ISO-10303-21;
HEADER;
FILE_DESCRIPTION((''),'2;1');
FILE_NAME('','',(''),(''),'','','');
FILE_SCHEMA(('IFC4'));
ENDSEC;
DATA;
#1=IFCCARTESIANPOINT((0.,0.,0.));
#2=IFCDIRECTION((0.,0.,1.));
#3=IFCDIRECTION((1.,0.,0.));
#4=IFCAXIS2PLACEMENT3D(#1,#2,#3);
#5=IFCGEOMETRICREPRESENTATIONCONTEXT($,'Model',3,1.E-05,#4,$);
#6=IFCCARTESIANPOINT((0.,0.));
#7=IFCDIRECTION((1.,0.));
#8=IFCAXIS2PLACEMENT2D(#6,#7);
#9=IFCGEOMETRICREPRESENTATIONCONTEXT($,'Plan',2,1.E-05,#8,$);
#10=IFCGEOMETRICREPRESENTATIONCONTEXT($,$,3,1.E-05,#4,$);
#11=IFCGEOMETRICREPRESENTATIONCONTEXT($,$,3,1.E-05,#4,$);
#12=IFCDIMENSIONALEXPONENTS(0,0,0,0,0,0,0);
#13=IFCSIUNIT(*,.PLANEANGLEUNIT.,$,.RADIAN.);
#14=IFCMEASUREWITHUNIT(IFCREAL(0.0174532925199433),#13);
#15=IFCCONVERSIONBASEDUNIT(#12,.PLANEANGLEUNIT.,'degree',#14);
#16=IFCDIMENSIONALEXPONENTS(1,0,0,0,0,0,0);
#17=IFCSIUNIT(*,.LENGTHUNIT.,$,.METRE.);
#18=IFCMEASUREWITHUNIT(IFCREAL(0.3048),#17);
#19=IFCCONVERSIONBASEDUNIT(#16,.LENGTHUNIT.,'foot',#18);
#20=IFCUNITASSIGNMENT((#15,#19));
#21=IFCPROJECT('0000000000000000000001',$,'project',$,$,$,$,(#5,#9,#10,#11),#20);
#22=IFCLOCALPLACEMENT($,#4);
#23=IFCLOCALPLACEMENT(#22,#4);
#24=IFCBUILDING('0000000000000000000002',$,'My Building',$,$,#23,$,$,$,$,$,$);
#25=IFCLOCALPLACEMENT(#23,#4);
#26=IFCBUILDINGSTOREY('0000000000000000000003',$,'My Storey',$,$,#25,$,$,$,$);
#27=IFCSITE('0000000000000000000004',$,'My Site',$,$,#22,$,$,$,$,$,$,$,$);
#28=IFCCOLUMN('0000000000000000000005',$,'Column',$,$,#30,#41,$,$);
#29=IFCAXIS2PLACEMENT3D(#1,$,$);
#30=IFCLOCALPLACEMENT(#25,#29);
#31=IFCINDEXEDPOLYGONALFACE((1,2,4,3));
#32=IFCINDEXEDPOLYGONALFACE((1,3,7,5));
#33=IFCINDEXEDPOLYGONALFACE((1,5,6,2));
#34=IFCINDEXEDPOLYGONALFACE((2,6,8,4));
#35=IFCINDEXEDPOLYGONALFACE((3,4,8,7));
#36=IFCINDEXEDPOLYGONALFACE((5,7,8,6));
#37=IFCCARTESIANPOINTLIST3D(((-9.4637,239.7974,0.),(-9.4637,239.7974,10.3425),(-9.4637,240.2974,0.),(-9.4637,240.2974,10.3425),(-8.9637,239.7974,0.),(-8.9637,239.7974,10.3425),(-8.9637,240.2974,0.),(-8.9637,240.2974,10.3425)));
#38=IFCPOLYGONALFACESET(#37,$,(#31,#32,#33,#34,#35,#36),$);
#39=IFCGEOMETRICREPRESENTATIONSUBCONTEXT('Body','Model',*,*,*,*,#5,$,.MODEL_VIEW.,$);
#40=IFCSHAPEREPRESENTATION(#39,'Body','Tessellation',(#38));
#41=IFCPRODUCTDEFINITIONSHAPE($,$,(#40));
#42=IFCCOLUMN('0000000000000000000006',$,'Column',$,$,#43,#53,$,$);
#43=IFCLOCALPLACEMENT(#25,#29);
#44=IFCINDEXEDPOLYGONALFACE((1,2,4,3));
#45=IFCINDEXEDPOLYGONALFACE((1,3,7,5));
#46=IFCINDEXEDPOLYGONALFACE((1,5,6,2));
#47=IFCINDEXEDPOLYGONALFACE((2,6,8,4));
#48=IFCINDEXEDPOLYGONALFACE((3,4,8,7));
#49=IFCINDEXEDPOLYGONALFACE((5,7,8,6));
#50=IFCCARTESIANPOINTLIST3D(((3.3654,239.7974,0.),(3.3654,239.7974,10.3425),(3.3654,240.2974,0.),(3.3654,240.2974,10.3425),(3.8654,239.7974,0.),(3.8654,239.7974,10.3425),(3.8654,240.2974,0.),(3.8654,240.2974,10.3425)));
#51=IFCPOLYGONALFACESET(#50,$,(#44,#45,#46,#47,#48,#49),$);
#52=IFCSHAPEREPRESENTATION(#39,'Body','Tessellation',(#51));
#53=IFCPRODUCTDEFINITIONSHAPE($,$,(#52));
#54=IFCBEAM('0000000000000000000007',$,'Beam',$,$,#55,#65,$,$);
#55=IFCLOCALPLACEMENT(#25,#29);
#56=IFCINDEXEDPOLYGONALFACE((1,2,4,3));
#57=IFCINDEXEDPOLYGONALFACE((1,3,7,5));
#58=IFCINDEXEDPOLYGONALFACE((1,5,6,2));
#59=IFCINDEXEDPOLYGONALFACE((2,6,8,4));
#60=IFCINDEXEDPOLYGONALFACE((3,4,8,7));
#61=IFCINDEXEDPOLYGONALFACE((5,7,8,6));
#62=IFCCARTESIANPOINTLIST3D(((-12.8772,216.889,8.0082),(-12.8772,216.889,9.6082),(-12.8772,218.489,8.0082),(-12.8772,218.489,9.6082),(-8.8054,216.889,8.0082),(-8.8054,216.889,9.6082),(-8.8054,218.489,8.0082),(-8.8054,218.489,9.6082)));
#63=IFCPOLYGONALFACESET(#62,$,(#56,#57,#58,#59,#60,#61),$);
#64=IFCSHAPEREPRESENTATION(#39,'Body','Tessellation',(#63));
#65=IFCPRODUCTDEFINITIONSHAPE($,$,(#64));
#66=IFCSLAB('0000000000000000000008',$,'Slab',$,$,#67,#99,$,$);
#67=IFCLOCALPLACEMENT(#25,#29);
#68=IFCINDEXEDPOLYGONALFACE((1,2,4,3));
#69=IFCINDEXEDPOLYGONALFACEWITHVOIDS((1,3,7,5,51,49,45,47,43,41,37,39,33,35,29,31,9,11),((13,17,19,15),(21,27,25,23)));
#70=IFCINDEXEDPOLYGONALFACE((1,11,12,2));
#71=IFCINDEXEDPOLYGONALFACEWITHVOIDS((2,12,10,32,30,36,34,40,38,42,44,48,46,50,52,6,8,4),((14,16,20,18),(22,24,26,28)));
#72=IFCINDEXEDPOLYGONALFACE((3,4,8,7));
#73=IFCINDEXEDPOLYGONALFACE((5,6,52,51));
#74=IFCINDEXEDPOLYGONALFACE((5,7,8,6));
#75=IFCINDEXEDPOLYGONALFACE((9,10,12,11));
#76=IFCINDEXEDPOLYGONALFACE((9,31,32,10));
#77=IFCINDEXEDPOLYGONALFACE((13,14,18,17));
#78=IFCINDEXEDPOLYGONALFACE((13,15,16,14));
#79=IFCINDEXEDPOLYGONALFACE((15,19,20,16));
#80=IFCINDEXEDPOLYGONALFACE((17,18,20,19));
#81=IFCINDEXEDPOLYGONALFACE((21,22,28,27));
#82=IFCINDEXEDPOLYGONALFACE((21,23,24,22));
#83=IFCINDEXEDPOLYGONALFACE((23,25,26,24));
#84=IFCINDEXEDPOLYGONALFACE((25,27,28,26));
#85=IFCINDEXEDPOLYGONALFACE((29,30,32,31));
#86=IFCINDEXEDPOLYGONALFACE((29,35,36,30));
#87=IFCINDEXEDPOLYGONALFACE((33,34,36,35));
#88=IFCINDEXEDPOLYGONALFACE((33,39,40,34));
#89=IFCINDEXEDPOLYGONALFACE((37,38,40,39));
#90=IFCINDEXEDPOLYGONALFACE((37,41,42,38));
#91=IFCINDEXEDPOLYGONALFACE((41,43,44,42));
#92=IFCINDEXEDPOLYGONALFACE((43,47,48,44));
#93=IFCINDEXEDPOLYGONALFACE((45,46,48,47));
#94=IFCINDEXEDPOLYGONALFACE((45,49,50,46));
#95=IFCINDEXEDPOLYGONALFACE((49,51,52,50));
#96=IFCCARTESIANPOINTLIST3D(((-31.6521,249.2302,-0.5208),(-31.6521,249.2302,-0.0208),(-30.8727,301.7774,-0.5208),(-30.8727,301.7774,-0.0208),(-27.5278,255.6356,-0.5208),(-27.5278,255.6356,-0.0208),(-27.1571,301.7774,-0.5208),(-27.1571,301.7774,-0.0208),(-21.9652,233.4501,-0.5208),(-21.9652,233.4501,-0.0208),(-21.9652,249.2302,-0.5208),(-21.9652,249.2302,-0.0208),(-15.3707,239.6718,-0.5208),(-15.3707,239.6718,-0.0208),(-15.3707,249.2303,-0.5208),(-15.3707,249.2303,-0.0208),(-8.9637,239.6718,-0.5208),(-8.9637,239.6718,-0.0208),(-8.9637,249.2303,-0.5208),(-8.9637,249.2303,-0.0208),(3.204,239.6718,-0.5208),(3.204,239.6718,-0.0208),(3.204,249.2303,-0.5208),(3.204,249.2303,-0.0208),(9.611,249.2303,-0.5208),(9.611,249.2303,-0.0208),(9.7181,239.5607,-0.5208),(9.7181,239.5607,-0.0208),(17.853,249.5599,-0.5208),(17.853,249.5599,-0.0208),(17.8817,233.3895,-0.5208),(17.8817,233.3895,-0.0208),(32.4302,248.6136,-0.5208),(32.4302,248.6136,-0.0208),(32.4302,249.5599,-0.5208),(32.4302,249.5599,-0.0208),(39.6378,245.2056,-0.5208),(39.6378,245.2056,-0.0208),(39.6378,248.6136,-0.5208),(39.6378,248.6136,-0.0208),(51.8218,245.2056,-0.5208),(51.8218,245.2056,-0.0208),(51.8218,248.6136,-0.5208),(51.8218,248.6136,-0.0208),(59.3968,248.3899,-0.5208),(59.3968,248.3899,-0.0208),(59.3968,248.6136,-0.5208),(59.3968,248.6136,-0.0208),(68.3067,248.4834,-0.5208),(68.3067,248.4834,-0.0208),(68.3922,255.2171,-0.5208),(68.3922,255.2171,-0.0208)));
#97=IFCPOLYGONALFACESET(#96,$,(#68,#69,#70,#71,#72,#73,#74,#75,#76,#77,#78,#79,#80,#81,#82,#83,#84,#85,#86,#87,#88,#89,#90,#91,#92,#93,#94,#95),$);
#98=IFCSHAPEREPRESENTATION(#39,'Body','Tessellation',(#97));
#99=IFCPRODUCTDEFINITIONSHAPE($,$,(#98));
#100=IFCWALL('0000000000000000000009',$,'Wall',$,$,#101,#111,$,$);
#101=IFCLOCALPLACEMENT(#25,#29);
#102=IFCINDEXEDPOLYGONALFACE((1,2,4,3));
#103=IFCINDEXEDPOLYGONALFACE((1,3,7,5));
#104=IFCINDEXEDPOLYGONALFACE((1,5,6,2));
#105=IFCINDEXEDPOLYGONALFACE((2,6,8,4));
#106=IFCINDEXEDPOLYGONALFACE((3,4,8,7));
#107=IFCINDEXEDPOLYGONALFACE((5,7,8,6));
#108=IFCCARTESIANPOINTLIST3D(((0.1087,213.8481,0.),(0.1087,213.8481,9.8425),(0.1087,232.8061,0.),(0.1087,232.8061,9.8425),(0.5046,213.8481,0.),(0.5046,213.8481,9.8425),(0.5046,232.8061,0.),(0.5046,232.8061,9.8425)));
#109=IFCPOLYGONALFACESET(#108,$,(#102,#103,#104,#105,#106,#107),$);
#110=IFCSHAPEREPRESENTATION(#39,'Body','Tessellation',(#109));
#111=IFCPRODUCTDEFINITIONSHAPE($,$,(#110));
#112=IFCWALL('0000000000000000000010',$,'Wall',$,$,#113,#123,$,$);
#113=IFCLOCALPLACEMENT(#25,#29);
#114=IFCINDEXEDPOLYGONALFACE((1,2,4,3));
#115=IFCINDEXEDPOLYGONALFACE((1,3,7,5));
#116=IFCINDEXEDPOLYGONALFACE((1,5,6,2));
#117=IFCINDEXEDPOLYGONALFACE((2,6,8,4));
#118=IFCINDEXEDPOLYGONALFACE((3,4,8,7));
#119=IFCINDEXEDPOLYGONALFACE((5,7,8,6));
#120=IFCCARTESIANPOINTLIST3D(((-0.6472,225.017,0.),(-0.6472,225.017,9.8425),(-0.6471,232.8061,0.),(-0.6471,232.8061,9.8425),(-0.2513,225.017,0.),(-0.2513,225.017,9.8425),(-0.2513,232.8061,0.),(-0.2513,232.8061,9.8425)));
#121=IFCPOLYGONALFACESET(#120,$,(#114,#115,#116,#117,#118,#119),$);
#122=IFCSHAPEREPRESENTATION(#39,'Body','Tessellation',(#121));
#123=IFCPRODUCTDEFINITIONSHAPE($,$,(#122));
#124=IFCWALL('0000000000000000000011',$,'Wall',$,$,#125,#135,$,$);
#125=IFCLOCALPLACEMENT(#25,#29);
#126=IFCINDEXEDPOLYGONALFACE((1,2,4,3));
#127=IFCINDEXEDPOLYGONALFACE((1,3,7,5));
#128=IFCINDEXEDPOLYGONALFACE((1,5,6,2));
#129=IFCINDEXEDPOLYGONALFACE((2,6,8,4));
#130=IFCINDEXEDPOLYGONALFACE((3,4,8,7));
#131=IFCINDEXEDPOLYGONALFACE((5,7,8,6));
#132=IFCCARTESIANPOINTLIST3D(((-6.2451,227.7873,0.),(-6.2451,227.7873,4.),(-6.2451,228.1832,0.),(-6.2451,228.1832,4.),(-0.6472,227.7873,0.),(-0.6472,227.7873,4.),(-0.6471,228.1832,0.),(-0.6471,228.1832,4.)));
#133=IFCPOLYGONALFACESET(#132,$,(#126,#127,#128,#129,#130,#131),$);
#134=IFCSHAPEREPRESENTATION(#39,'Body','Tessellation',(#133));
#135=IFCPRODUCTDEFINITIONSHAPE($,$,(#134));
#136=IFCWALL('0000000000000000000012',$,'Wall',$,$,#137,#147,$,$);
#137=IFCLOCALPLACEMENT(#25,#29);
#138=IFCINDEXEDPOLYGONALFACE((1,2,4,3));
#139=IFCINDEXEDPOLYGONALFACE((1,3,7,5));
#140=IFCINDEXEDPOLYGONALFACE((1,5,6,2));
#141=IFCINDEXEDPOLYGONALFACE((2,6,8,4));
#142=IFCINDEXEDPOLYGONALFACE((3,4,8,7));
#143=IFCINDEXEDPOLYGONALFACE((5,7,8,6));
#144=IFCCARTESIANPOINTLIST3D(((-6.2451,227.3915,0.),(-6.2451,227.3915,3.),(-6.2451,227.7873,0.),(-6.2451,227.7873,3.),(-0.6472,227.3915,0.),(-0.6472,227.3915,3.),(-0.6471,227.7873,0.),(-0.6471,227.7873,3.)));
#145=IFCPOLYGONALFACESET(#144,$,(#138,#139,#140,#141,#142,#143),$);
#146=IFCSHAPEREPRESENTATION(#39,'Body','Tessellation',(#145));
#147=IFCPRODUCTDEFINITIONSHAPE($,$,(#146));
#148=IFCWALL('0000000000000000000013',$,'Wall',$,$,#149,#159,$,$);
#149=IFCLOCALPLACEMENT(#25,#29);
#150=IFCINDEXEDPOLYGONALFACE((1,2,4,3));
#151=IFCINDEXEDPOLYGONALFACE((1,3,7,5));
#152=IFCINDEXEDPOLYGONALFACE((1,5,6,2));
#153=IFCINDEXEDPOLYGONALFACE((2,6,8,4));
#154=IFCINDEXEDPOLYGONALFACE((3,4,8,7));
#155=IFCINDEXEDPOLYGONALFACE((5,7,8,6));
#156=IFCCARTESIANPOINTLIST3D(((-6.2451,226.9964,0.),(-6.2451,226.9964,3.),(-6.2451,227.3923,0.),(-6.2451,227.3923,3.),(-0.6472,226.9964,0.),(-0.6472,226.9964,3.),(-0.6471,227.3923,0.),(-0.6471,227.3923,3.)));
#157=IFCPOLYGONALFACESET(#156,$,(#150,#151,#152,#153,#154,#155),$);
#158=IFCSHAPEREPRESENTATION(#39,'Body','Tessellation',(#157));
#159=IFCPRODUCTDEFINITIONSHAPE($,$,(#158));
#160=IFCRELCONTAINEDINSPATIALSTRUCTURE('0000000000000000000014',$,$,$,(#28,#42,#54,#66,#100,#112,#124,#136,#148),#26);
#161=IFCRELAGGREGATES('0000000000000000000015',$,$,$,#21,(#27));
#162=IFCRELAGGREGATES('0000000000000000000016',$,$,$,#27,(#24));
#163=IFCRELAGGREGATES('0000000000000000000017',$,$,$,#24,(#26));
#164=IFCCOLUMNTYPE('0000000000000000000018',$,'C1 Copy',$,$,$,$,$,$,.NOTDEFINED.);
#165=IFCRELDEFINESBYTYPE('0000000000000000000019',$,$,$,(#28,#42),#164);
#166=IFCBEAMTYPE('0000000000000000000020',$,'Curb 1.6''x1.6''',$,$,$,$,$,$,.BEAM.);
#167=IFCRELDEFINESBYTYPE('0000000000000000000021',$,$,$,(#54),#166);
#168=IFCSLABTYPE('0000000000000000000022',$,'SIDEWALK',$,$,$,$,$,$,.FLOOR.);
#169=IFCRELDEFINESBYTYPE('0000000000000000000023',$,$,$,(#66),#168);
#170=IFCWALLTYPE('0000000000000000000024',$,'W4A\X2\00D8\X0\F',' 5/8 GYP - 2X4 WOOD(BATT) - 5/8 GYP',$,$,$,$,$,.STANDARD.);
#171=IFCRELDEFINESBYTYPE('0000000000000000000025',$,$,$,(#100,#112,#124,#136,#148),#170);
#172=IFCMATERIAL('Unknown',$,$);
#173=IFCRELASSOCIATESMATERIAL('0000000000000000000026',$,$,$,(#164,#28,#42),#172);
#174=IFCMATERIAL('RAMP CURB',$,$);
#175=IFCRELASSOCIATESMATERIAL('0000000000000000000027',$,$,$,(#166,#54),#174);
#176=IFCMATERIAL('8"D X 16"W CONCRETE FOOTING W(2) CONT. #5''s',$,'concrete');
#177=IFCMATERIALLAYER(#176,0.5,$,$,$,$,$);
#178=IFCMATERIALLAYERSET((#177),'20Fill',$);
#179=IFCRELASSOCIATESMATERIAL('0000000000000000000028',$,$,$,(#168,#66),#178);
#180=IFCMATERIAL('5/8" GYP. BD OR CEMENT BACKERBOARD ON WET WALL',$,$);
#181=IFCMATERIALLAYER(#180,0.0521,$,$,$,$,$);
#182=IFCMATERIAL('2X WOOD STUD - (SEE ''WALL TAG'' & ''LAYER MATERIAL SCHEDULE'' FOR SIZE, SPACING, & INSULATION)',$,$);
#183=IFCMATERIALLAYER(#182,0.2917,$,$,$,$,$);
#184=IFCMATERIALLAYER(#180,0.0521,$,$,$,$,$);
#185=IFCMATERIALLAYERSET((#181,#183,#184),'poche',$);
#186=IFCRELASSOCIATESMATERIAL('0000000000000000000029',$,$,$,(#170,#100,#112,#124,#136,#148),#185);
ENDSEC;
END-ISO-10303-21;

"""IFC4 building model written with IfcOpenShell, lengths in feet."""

from ifc_helpers import new_model, entity, si_unit, converted_unit, frame, origin_with_axes, origin_2d_with_axis, place, context, subcontext, project, spatial, line, indexed_curve, rectangle, outline, extrude, material, layer, layer_set, layer_usage, material_profile, profile_set, profile_usage, type_object, element, save


model = new_model("IFC4")

# Units and contexts
model_context = context("Model", 3, precision=1e-05, world=origin_with_axes())
plan_context = context("Plan", 2, precision=1e-05, world=origin_2d_with_axis())
context_of_model_1 = context(None, 3, precision=1e-05, world=origin_with_axes())
context_of_model_2 = context(None, 3, precision=1e-05, world=origin_with_axes())
body_context_1 = subcontext(model_context, "Body", "Model", "MODEL_VIEW")
ifc_project = project(units=[converted_unit("PLANEANGLEUNIT", "degree", entity("IfcReal", 0.0174532925199433), si_unit("PLANEANGLEUNIT", "RADIAN"), dimensions=[0, 0, 0, 0, 0, 0, 0]), converted_unit("LENGTHUNIT", "foot", entity("IfcReal", 0.3048), si_unit("LENGTHUNIT", "METRE"), dimensions=[1, 0, 0, 0, 0, 0, 0])], contexts=[model_context, plan_context, context_of_model_1, context_of_model_2])

# Site, building, storey
site_placement = place(None, origin_with_axes())
site = spatial("IfcSite", under=ifc_project, at=site_placement, Name="My Site")
building_placement = place(site_placement, origin_with_axes())
building = spatial("IfcBuilding", under=site, at=building_placement, Name="My Building")
storey_placement = place(building_placement, origin_with_axes())
storey = spatial("IfcBuildingStorey", under=building, at=storey_placement, Name="My Storey")

# Columns
ifc_material_1 = material(Name="Unknown")
ifc_material_profile_1 = material_profile(ifc_material_1, rectangle(XDim=0.5, YDim=0.5))
ifc_profile_set_1 = profile_set([ifc_material_profile_1])
ifc_profile_usage_1 = profile_usage(ifc_profile_set_1, cardinal=5)
column_type = type_object("IfcColumnType", Name="C1 Copy", PredefinedType="NOTDEFINED", material=ifc_profile_set_1)
column_1_placement = place(storey_placement, frame((-9.2137, 240.0474, 0.0), z_axis=(0.0, 0.0, 1.0), x_axis=(1.0, 0.0, 0.0)))
element("IfcColumn", 1, at=column_1_placement, inside=storey, type_object=column_type, material=ifc_profile_usage_1, Name="Column", context=body_context_1, shape_type="SweptSolid", body=[
    extrude(rectangle(XDim=0.5, YDim=0.5), origin_with_axes(), (0.0, 0.0, 1.0), 10.3425),
])
ifc_profile_usage_2 = profile_usage(ifc_profile_set_1, cardinal=5)
column_2_placement = place(storey_placement, frame((3.6154, 240.0474, 0.0), z_axis=(0.0, 0.0, 1.0), x_axis=(1.0, 0.0, 0.0)))
element("IfcColumn", 2, at=column_2_placement, inside=storey, type_object=column_type, material=ifc_profile_usage_2, Name="Column", context=body_context_1, shape_type="SweptSolid", body=[
    extrude(rectangle(XDim=0.5, YDim=0.5), origin_with_axes(), (0.0, 0.0, 1.0), 10.3425),
])

# Beam
ifc_material_2 = material(Name="RAMP CURB")
ifc_material_profile_2 = material_profile(ifc_material_2, rectangle(XDim=1.6, YDim=1.6))
ifc_profile_set_2 = profile_set([ifc_material_profile_2])
ifc_profile_usage_3 = profile_usage(ifc_profile_set_2, cardinal=5)
beam_type = type_object("IfcBeamType", Name="Curb 1.6'x1.6'", PredefinedType="BEAM", material=ifc_profile_set_2)
beam_placement = place(storey_placement, frame((-8.8054, 217.689, 8.8082), z_axis=(-1.0, 0.0, 0.0), x_axis=(0.0, -1.0, 0.0)))
element("IfcBeam", 3, at=beam_placement, inside=storey, type_object=beam_type, material=ifc_profile_usage_3, Name="Beam", context=body_context_1, shape_type="SweptSolid", body=[
    extrude(rectangle(XDim=1.6, YDim=1.6), origin_with_axes(), (0.0, 0.0, 1.0), 4.0718),
])

# Slab
ifc_material_3 = material(Name="8\"D X 16\"W CONCRETE FOOTING W(2) CONT. #5's", Category="concrete")
ifc_layer_1 = layer(ifc_material_3, 0.5)
ifc_layer_set_1 = layer_set([ifc_layer_1], Name="20Fill")
ifc_layer_usage_1 = layer_usage(ifc_layer_set_1, "AXIS3", "POSITIVE", 0.0)
slab_type_1 = type_object("IfcSlabType", Name="SIDEWALK", PredefinedType="FLOOR", material=ifc_layer_set_1)
slab_1_placement = place(storey_placement, frame((3.204, 249.2303, -0.5208), z_axis=(0.0, 0.0, 1.0), x_axis=(1.0, 0.0, 0.0)))
element("IfcSlab", 4, at=slab_1_placement, inside=storey, type_object=slab_type_1, material=ifc_layer_usage_1, Name="Slab", context=body_context_1, shape_type="SweptSolid", body=[
    extrude(outline(indexed_curve([(-30.3611, 52.5471), (-34.0767, 52.5471), (-34.856, 0.0), (-25.1691, 0.0), (-25.1691, -15.7802), (14.6777, -15.8408), (14.6491, 0.3296), (36.4338, -0.6167), (36.4338, -4.0246), (48.6178, -4.0246), (48.6178, -0.6167), (56.1929, -0.6167), (56.1929, -0.8404), (65.1027, -0.7468), (65.1882, 5.9868), (-30.7318, 6.4054), (-18.5747, 0.0), (-18.5747, -9.5584), (-12.1677, -9.5584), (-12.1677, 0.0), (6.5141, -9.6695), (6.407, 0.0), (0.0, 0.0), (0.0, -9.5584), (29.2262, 0.3296), (29.2262, -0.6167)], segments=[line(4, 3), line(3, 2), line(2, 1), line(1, 16), line(16, 15), line(15, 14), line(14, 13), line(13, 12), line(12, 11), line(11, 10), line(10, 9), line(9, 8), line(8, 26), line(26, 25), line(25, 7), line(7, 6), line(6, 5), line(5, 4)], self_intersect=False), holes=[indexed_curve([(-30.3611, 52.5471), (-34.0767, 52.5471), (-34.856, 0.0), (-25.1691, 0.0), (-25.1691, -15.7802), (14.6777, -15.8408), (14.6491, 0.3296), (36.4338, -0.6167), (36.4338, -4.0246), (48.6178, -4.0246), (48.6178, -0.6167), (56.1929, -0.6167), (56.1929, -0.8404), (65.1027, -0.7468), (65.1882, 5.9868), (-30.7318, 6.4054), (-18.5747, 0.0), (-18.5747, -9.5584), (-12.1677, -9.5584), (-12.1677, 0.0), (6.5141, -9.6695), (6.407, 0.0), (0.0, 0.0), (0.0, -9.5584), (29.2262, 0.3296), (29.2262, -0.6167)], segments=[line(24, 23), line(23, 22), line(22, 21), line(21, 24)], self_intersect=False), indexed_curve([(-30.3611, 52.5471), (-34.0767, 52.5471), (-34.856, 0.0), (-25.1691, 0.0), (-25.1691, -15.7802), (14.6777, -15.8408), (14.6491, 0.3296), (36.4338, -0.6167), (36.4338, -4.0246), (48.6178, -4.0246), (48.6178, -0.6167), (56.1929, -0.6167), (56.1929, -0.8404), (65.1027, -0.7468), (65.1882, 5.9868), (-30.7318, 6.4054), (-18.5747, 0.0), (-18.5747, -9.5584), (-12.1677, -9.5584), (-12.1677, 0.0), (6.5141, -9.6695), (6.407, 0.0), (0.0, 0.0), (0.0, -9.5584), (29.2262, 0.3296), (29.2262, -0.6167)], segments=[line(18, 19), line(19, 20), line(20, 17), line(17, 18)], self_intersect=False)]), None, (0.0, 0.0, 1.0), 0.5),
])

# Walls
ifc_material_4 = material(Name="5/8\" GYP. BD OR CEMENT BACKERBOARD ON WET WALL")
ifc_layer_2 = layer(ifc_material_4, 0.0521)
ifc_material_5 = material(Name="2X WOOD STUD - (SEE 'WALL TAG' & 'LAYER MATERIAL SCHEDULE' FOR SIZE, SPACING, & INSULATION)")
ifc_layer_3 = layer(ifc_material_5, 0.2917)
ifc_layer_4 = layer(ifc_material_4, 0.0521)
ifc_layer_set_2 = layer_set([ifc_layer_2, ifc_layer_3, ifc_layer_4], Name="poche")
wall_type_1 = type_object("IfcWallType", Name="W4AØF", Description=" 5/8 GYP - 2X4 WOOD(BATT) - 5/8 GYP", PredefinedType="STANDARD", material=ifc_layer_set_2)
ifc_layer_usage_2 = layer_usage(ifc_layer_set_2, "AXIS2", "POSITIVE", 0.0)
wall_1_placement = place(storey_placement, frame((0.5046, 213.8481, 0.0), z_axis=(0.0, 0.0, 1.0), x_axis=(0.000001, 1.0, 0.0)))
element("IfcWall", 5, at=wall_1_placement, inside=storey, type_object=wall_type_1, material=ifc_layer_usage_2, Name="Wall", context=body_context_1, shape_type="SweptSolid", body=[
    extrude(outline(indexed_curve([(0.0, 0.0), (0.0, 0.3958), (18.958, 0.3958), (18.958, 0.0), (0.0, 0.0)], self_intersect=False)), origin_with_axes(), (0.0, 0.0, 1.0), 9.8425),
])
ifc_layer_usage_3 = layer_usage(ifc_layer_set_2, "AXIS2", "POSITIVE", 0.0)
wall_2_placement = place(storey_placement, frame((-0.2513, 225.017, 0.0), z_axis=(0.0, 0.0, 1.0), x_axis=(0.0, 1.0, 0.0)))
element("IfcWall", 6, at=wall_2_placement, inside=storey, type_object=wall_type_1, material=ifc_layer_usage_3, Name="Wall", context=body_context_1, shape_type="SweptSolid", body=[
    extrude(outline(indexed_curve([(0.0, 0.0), (0.0, 0.3958), (7.7891, 0.3958), (7.7891, 0.0), (0.0, 0.0)], self_intersect=False)), origin_with_axes(), (0.0, 0.0, 1.0), 9.8425),
])
ifc_layer_usage_4 = layer_usage(ifc_layer_set_2, "AXIS2", "POSITIVE", 0.0)
wall_3_placement = place(storey_placement, frame((-0.6471, 228.1832, 0.0), z_axis=(0.0, 0.0, 1.0), x_axis=(-1.0, 0.0, 0.0)))
element("IfcWall", 7, at=wall_3_placement, inside=storey, type_object=wall_type_1, material=ifc_layer_usage_4, Name="Wall", context=body_context_1, shape_type="SweptSolid", body=[
    extrude(outline(indexed_curve([(0.0, 0.0), (0.0, 0.3958), (5.5979, 0.3958), (5.5979, 0.0), (0.0, 0.0)], self_intersect=False)), origin_with_axes(), (0.0, 0.0, 1.0), 4.0),
])
ifc_layer_usage_5 = layer_usage(ifc_layer_set_2, "AXIS2", "POSITIVE", 0.0)
wall_4_placement = place(storey_placement, frame((-0.6471, 227.7873, 0.0), z_axis=(0.0, 0.0, 1.0), x_axis=(-1.0, 0.0, 0.0)))
element("IfcWall", 8, at=wall_4_placement, inside=storey, type_object=wall_type_1, material=ifc_layer_usage_5, Name="Wall", context=body_context_1, shape_type="SweptSolid", body=[
    extrude(outline(indexed_curve([(0.0, 0.0), (0.0, 0.3958), (5.5979, 0.3958), (5.5979, 0.0), (0.0, 0.0)], self_intersect=False)), origin_with_axes(), (0.0, 0.0, 1.0), 3.0),
])
ifc_layer_usage_6 = layer_usage(ifc_layer_set_2, "AXIS2", "POSITIVE", 0.0)
wall_5_placement = place(storey_placement, frame((-0.6471, 227.3923, 0.0), z_axis=(0.0, 0.0, 1.0), x_axis=(-1.0, 0.0, 0.0)))
element("IfcWall", 9, at=wall_5_placement, inside=storey, type_object=wall_type_1, material=ifc_layer_usage_6, Name="Wall", context=body_context_1, shape_type="SweptSolid", body=[
    extrude(outline(indexed_curve([(0.0, 0.0), (0.0, 0.3958), (5.5979, 0.3958), (5.5979, 0.0), (0.0, 0.0)], self_intersect=False)), origin_with_axes(), (0.0, 0.0, 1.0), 3.0),
])

save(model, "model.ifc")
